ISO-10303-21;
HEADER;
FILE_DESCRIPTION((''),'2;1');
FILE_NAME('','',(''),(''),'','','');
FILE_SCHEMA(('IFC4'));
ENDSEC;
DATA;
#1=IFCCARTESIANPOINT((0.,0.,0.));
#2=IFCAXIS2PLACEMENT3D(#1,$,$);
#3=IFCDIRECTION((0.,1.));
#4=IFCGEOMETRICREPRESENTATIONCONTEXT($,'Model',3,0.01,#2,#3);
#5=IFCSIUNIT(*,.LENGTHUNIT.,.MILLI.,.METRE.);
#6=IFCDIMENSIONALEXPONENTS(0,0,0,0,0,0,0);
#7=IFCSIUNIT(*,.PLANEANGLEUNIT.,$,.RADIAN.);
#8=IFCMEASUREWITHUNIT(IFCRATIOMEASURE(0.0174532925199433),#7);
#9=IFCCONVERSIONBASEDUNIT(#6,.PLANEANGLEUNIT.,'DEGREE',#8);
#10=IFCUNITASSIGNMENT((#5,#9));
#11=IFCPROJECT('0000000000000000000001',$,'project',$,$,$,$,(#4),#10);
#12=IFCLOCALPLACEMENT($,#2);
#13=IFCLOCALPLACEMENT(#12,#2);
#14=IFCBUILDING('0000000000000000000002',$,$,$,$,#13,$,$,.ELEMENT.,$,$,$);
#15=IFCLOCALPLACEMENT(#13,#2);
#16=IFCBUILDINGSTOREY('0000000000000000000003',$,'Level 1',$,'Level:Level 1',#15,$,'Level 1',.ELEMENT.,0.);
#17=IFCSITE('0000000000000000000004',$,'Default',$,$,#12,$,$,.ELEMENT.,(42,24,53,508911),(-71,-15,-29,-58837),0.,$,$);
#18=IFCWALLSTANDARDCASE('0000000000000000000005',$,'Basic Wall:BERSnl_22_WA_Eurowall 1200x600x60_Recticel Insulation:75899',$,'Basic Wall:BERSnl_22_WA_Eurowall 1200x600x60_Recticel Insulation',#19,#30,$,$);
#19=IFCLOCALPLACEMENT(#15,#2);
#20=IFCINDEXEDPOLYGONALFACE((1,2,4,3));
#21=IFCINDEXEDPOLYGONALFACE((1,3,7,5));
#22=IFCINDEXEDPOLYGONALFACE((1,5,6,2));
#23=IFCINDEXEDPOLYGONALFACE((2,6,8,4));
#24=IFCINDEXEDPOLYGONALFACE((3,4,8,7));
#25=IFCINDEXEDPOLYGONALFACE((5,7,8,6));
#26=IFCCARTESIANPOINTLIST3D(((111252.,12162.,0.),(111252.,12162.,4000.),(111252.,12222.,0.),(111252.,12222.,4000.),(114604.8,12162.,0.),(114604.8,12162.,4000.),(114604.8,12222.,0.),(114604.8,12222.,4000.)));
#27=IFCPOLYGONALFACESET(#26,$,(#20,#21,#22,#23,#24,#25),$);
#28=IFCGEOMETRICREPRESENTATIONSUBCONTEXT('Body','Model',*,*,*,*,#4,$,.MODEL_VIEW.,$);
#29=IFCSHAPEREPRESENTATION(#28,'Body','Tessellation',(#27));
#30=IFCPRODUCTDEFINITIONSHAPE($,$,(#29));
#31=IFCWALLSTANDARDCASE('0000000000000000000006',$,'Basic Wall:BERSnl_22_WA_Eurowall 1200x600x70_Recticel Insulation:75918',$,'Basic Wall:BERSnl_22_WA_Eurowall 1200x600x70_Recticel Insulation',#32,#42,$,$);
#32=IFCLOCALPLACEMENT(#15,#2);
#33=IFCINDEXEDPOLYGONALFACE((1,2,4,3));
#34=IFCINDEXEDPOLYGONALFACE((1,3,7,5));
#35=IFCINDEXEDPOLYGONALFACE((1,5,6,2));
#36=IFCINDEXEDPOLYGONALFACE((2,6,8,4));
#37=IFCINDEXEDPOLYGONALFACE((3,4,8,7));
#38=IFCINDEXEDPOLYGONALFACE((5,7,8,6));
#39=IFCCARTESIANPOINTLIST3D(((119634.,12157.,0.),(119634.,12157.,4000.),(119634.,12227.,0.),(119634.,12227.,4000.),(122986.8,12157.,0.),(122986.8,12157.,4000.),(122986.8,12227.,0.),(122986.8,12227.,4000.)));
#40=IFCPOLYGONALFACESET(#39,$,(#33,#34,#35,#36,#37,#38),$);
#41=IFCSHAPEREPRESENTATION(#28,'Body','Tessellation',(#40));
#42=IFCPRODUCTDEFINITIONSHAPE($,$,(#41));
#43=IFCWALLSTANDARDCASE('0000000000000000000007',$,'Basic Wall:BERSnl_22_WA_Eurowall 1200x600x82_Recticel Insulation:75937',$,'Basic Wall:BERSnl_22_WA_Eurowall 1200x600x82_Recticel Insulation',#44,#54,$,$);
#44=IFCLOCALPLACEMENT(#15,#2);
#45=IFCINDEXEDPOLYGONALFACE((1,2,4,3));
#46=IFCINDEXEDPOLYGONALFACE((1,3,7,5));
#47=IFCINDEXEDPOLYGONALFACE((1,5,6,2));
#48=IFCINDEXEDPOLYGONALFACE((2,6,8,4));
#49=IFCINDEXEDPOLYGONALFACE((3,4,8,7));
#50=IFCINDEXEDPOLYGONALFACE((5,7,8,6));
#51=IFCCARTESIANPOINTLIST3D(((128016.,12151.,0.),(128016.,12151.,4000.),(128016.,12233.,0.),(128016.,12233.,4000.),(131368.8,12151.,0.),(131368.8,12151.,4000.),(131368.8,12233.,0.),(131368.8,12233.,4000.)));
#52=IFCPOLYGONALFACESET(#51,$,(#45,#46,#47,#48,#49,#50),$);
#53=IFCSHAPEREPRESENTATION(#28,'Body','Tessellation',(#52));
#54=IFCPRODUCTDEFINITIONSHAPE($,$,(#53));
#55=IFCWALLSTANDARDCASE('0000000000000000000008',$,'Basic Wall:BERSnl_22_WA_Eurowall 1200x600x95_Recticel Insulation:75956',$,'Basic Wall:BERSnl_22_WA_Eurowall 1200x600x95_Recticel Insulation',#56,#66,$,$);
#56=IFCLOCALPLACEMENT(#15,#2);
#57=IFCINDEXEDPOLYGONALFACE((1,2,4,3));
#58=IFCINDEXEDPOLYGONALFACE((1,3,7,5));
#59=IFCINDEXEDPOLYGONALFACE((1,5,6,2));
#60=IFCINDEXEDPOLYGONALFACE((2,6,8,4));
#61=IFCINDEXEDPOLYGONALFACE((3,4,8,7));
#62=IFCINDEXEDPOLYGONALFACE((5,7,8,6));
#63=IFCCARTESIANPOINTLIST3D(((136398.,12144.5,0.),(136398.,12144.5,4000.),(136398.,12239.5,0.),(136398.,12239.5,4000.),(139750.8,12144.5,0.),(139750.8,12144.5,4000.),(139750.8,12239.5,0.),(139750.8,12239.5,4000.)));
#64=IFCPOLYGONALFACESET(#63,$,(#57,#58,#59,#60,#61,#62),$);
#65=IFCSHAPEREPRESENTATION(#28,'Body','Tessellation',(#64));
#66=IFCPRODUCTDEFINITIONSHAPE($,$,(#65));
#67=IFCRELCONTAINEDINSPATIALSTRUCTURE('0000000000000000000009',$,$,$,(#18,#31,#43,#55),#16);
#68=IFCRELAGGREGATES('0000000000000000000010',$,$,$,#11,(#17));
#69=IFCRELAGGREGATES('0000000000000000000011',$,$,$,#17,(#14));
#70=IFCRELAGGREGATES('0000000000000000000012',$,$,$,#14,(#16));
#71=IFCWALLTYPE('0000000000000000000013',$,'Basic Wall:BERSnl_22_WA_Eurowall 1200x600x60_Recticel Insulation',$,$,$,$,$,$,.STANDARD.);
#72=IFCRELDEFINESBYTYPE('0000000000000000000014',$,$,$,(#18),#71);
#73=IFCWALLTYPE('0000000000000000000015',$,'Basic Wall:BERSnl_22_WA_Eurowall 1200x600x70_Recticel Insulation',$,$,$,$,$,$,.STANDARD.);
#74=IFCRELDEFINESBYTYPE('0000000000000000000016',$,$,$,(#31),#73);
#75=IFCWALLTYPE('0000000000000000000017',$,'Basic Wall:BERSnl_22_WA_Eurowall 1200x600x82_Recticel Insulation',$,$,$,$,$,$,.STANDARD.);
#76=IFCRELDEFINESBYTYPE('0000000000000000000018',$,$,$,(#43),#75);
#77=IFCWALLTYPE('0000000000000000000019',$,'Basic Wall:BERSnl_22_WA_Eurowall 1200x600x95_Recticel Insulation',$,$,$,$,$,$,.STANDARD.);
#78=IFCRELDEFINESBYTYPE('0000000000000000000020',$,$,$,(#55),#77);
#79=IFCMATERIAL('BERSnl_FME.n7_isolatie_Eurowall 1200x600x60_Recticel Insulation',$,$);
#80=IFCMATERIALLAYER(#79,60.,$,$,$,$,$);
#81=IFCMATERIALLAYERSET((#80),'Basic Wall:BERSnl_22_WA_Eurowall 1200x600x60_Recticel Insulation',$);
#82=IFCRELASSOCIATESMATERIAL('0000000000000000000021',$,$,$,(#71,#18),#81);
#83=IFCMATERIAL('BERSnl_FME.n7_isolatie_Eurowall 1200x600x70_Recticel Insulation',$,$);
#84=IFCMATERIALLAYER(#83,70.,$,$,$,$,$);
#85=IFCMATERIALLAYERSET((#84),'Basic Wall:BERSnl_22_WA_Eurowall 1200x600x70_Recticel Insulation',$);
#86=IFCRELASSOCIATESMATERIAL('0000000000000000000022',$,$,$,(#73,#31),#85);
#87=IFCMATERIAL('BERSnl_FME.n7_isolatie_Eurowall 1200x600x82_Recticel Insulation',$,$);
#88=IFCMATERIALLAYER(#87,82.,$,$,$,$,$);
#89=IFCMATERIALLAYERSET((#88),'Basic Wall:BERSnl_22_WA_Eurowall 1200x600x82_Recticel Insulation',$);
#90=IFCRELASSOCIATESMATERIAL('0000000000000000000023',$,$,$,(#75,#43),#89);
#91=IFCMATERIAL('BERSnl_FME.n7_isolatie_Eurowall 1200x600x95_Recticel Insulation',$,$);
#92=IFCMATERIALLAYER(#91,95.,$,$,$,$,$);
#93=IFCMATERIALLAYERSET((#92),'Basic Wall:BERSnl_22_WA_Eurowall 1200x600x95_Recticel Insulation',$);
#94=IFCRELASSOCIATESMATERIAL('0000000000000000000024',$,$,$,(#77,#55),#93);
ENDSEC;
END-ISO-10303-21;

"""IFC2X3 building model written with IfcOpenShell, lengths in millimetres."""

from ifc_helpers import new_model, entity, si_unit, converted_unit, direction, frame, frame_2d, origin, place, context, subcontext, project, spatial, rectangle, extrude, material, layer, layer_set, layer_usage, type_object, element, save


model = new_model("IFC2X3")

# Units and contexts
model_context = context("Model", 3, precision=0.01, world=origin(), true_north=direction((0.0, 1.0)))
body_context = subcontext(model_context, "Body", "Model", "MODEL_VIEW")
ifc_project = project(units=[si_unit("LENGTHUNIT", "METRE", prefix="MILLI"), converted_unit("PLANEANGLEUNIT", "DEGREE", entity("IfcRatioMeasure", 0.0174532925199433), si_unit("PLANEANGLEUNIT", "RADIAN"), dimensions=[0, 0, 0, 0, 0, 0, 0])], contexts=[model_context])

# Site, building, storey
site_placement = place(None, origin())
site = spatial("IfcSite", under=ifc_project, at=site_placement, Name="Default", CompositionType="ELEMENT", RefLatitude=(42, 24, 53, 508911), RefLongitude=(-71, -15, -29, -58837), RefElevation=0.0)
building_placement = place(site_placement, origin())
building = spatial("IfcBuilding", under=site, at=building_placement, CompositionType="ELEMENT")
storey_placement = place(building_placement, origin())
storey = spatial("IfcBuildingStorey", under=building, at=storey_placement, Name="Level 1", ObjectType="Level:Level 1", LongName="Level 1", CompositionType="ELEMENT", Elevation=0.0)

# Walls
ifc_material_1 = material(Name="BERSnl_FME.n7_isolatie_Eurowall 1200x600x60_Recticel Insulation")
ifc_layer_1 = layer(ifc_material_1, 60.0)
ifc_layer_set_1 = layer_set([ifc_layer_1], Name="Basic Wall:BERSnl_22_WA_Eurowall 1200x600x60_Recticel Insulation")
ifc_layer_usage_1 = layer_usage(ifc_layer_set_1, "AXIS2", "NEGATIVE", 30.0)
wall_type_1 = type_object("IfcWallType", Name="Basic Wall:BERSnl_22_WA_Eurowall 1200x600x60_Recticel Insulation", PredefinedType="STANDARD", material=ifc_layer_set_1)
wall_1_placement = place(storey_placement, frame((111252.0, 12192.0, 0.0)))
element("IfcWallStandardCase", 1, at=wall_1_placement, inside=storey, type_object=wall_type_1, material=ifc_layer_usage_1, Name="Basic Wall:BERSnl_22_WA_Eurowall 1200x600x60_Recticel Insulation:75899", ObjectType="Basic Wall:BERSnl_22_WA_Eurowall 1200x600x60_Recticel Insulation", context=body_context, shape_type="SweptSolid", body=[
    extrude(rectangle(XDim=3352.8, YDim=60.0, at=frame_2d((1676.4, 0.0), x_axis=(-1.0, 0.0))), origin(), (0.0, 0.0, 1.0), 4000.0),
])
ifc_material_2 = material(Name="BERSnl_FME.n7_isolatie_Eurowall 1200x600x70_Recticel Insulation")
ifc_layer_2 = layer(ifc_material_2, 70.0)
ifc_layer_set_2 = layer_set([ifc_layer_2], Name="Basic Wall:BERSnl_22_WA_Eurowall 1200x600x70_Recticel Insulation")
ifc_layer_usage_2 = layer_usage(ifc_layer_set_2, "AXIS2", "NEGATIVE", 35.0)
wall_type_2 = type_object("IfcWallType", Name="Basic Wall:BERSnl_22_WA_Eurowall 1200x600x70_Recticel Insulation", PredefinedType="STANDARD", material=ifc_layer_set_2)
wall_2_placement = place(storey_placement, frame((119634.0, 12192.0, 0.0)))
element("IfcWallStandardCase", 2, at=wall_2_placement, inside=storey, type_object=wall_type_2, material=ifc_layer_usage_2, Name="Basic Wall:BERSnl_22_WA_Eurowall 1200x600x70_Recticel Insulation:75918", ObjectType="Basic Wall:BERSnl_22_WA_Eurowall 1200x600x70_Recticel Insulation", context=body_context, shape_type="SweptSolid", body=[
    extrude(rectangle(XDim=3352.8, YDim=70.0, at=frame_2d((1676.4, 0.0), x_axis=(-1.0, 0.0))), origin(), (0.0, 0.0, 1.0), 4000.0),
])
ifc_material_3 = material(Name="BERSnl_FME.n7_isolatie_Eurowall 1200x600x82_Recticel Insulation")
ifc_layer_3 = layer(ifc_material_3, 82.0)
ifc_layer_set_3 = layer_set([ifc_layer_3], Name="Basic Wall:BERSnl_22_WA_Eurowall 1200x600x82_Recticel Insulation")
ifc_layer_usage_3 = layer_usage(ifc_layer_set_3, "AXIS2", "NEGATIVE", 41.0)
wall_type_3 = type_object("IfcWallType", Name="Basic Wall:BERSnl_22_WA_Eurowall 1200x600x82_Recticel Insulation", PredefinedType="STANDARD", material=ifc_layer_set_3)
wall_3_placement = place(storey_placement, frame((128016.0, 12192.0, 0.0)))
element("IfcWallStandardCase", 3, at=wall_3_placement, inside=storey, type_object=wall_type_3, material=ifc_layer_usage_3, Name="Basic Wall:BERSnl_22_WA_Eurowall 1200x600x82_Recticel Insulation:75937", ObjectType="Basic Wall:BERSnl_22_WA_Eurowall 1200x600x82_Recticel Insulation", context=body_context, shape_type="SweptSolid", body=[
    extrude(rectangle(XDim=3352.8, YDim=82.0, at=frame_2d((1676.4, 0.0), x_axis=(-1.0, 0.0))), origin(), (0.0, 0.0, 1.0), 4000.0),
])
ifc_material_4 = material(Name="BERSnl_FME.n7_isolatie_Eurowall 1200x600x95_Recticel Insulation")
ifc_layer_4 = layer(ifc_material_4, 95.0)
ifc_layer_set_4 = layer_set([ifc_layer_4], Name="Basic Wall:BERSnl_22_WA_Eurowall 1200x600x95_Recticel Insulation")
ifc_layer_usage_4 = layer_usage(ifc_layer_set_4, "AXIS2", "NEGATIVE", 47.5)
wall_type_4 = type_object("IfcWallType", Name="Basic Wall:BERSnl_22_WA_Eurowall 1200x600x95_Recticel Insulation", PredefinedType="STANDARD", material=ifc_layer_set_4)
wall_4_placement = place(storey_placement, frame((136398.0, 12192.0, 0.0)))
element("IfcWallStandardCase", 4, at=wall_4_placement, inside=storey, type_object=wall_type_4, material=ifc_layer_usage_4, Name="Basic Wall:BERSnl_22_WA_Eurowall 1200x600x95_Recticel Insulation:75956", ObjectType="Basic Wall:BERSnl_22_WA_Eurowall 1200x600x95_Recticel Insulation", context=body_context, shape_type="SweptSolid", body=[
    extrude(rectangle(XDim=3352.8, YDim=95.0, at=frame_2d((1676.4, 0.0), x_axis=(-1.0, 0.0))), origin(), (0.0, 0.0, 1.0), 4000.0),
])

save(model, "model.ifc")
